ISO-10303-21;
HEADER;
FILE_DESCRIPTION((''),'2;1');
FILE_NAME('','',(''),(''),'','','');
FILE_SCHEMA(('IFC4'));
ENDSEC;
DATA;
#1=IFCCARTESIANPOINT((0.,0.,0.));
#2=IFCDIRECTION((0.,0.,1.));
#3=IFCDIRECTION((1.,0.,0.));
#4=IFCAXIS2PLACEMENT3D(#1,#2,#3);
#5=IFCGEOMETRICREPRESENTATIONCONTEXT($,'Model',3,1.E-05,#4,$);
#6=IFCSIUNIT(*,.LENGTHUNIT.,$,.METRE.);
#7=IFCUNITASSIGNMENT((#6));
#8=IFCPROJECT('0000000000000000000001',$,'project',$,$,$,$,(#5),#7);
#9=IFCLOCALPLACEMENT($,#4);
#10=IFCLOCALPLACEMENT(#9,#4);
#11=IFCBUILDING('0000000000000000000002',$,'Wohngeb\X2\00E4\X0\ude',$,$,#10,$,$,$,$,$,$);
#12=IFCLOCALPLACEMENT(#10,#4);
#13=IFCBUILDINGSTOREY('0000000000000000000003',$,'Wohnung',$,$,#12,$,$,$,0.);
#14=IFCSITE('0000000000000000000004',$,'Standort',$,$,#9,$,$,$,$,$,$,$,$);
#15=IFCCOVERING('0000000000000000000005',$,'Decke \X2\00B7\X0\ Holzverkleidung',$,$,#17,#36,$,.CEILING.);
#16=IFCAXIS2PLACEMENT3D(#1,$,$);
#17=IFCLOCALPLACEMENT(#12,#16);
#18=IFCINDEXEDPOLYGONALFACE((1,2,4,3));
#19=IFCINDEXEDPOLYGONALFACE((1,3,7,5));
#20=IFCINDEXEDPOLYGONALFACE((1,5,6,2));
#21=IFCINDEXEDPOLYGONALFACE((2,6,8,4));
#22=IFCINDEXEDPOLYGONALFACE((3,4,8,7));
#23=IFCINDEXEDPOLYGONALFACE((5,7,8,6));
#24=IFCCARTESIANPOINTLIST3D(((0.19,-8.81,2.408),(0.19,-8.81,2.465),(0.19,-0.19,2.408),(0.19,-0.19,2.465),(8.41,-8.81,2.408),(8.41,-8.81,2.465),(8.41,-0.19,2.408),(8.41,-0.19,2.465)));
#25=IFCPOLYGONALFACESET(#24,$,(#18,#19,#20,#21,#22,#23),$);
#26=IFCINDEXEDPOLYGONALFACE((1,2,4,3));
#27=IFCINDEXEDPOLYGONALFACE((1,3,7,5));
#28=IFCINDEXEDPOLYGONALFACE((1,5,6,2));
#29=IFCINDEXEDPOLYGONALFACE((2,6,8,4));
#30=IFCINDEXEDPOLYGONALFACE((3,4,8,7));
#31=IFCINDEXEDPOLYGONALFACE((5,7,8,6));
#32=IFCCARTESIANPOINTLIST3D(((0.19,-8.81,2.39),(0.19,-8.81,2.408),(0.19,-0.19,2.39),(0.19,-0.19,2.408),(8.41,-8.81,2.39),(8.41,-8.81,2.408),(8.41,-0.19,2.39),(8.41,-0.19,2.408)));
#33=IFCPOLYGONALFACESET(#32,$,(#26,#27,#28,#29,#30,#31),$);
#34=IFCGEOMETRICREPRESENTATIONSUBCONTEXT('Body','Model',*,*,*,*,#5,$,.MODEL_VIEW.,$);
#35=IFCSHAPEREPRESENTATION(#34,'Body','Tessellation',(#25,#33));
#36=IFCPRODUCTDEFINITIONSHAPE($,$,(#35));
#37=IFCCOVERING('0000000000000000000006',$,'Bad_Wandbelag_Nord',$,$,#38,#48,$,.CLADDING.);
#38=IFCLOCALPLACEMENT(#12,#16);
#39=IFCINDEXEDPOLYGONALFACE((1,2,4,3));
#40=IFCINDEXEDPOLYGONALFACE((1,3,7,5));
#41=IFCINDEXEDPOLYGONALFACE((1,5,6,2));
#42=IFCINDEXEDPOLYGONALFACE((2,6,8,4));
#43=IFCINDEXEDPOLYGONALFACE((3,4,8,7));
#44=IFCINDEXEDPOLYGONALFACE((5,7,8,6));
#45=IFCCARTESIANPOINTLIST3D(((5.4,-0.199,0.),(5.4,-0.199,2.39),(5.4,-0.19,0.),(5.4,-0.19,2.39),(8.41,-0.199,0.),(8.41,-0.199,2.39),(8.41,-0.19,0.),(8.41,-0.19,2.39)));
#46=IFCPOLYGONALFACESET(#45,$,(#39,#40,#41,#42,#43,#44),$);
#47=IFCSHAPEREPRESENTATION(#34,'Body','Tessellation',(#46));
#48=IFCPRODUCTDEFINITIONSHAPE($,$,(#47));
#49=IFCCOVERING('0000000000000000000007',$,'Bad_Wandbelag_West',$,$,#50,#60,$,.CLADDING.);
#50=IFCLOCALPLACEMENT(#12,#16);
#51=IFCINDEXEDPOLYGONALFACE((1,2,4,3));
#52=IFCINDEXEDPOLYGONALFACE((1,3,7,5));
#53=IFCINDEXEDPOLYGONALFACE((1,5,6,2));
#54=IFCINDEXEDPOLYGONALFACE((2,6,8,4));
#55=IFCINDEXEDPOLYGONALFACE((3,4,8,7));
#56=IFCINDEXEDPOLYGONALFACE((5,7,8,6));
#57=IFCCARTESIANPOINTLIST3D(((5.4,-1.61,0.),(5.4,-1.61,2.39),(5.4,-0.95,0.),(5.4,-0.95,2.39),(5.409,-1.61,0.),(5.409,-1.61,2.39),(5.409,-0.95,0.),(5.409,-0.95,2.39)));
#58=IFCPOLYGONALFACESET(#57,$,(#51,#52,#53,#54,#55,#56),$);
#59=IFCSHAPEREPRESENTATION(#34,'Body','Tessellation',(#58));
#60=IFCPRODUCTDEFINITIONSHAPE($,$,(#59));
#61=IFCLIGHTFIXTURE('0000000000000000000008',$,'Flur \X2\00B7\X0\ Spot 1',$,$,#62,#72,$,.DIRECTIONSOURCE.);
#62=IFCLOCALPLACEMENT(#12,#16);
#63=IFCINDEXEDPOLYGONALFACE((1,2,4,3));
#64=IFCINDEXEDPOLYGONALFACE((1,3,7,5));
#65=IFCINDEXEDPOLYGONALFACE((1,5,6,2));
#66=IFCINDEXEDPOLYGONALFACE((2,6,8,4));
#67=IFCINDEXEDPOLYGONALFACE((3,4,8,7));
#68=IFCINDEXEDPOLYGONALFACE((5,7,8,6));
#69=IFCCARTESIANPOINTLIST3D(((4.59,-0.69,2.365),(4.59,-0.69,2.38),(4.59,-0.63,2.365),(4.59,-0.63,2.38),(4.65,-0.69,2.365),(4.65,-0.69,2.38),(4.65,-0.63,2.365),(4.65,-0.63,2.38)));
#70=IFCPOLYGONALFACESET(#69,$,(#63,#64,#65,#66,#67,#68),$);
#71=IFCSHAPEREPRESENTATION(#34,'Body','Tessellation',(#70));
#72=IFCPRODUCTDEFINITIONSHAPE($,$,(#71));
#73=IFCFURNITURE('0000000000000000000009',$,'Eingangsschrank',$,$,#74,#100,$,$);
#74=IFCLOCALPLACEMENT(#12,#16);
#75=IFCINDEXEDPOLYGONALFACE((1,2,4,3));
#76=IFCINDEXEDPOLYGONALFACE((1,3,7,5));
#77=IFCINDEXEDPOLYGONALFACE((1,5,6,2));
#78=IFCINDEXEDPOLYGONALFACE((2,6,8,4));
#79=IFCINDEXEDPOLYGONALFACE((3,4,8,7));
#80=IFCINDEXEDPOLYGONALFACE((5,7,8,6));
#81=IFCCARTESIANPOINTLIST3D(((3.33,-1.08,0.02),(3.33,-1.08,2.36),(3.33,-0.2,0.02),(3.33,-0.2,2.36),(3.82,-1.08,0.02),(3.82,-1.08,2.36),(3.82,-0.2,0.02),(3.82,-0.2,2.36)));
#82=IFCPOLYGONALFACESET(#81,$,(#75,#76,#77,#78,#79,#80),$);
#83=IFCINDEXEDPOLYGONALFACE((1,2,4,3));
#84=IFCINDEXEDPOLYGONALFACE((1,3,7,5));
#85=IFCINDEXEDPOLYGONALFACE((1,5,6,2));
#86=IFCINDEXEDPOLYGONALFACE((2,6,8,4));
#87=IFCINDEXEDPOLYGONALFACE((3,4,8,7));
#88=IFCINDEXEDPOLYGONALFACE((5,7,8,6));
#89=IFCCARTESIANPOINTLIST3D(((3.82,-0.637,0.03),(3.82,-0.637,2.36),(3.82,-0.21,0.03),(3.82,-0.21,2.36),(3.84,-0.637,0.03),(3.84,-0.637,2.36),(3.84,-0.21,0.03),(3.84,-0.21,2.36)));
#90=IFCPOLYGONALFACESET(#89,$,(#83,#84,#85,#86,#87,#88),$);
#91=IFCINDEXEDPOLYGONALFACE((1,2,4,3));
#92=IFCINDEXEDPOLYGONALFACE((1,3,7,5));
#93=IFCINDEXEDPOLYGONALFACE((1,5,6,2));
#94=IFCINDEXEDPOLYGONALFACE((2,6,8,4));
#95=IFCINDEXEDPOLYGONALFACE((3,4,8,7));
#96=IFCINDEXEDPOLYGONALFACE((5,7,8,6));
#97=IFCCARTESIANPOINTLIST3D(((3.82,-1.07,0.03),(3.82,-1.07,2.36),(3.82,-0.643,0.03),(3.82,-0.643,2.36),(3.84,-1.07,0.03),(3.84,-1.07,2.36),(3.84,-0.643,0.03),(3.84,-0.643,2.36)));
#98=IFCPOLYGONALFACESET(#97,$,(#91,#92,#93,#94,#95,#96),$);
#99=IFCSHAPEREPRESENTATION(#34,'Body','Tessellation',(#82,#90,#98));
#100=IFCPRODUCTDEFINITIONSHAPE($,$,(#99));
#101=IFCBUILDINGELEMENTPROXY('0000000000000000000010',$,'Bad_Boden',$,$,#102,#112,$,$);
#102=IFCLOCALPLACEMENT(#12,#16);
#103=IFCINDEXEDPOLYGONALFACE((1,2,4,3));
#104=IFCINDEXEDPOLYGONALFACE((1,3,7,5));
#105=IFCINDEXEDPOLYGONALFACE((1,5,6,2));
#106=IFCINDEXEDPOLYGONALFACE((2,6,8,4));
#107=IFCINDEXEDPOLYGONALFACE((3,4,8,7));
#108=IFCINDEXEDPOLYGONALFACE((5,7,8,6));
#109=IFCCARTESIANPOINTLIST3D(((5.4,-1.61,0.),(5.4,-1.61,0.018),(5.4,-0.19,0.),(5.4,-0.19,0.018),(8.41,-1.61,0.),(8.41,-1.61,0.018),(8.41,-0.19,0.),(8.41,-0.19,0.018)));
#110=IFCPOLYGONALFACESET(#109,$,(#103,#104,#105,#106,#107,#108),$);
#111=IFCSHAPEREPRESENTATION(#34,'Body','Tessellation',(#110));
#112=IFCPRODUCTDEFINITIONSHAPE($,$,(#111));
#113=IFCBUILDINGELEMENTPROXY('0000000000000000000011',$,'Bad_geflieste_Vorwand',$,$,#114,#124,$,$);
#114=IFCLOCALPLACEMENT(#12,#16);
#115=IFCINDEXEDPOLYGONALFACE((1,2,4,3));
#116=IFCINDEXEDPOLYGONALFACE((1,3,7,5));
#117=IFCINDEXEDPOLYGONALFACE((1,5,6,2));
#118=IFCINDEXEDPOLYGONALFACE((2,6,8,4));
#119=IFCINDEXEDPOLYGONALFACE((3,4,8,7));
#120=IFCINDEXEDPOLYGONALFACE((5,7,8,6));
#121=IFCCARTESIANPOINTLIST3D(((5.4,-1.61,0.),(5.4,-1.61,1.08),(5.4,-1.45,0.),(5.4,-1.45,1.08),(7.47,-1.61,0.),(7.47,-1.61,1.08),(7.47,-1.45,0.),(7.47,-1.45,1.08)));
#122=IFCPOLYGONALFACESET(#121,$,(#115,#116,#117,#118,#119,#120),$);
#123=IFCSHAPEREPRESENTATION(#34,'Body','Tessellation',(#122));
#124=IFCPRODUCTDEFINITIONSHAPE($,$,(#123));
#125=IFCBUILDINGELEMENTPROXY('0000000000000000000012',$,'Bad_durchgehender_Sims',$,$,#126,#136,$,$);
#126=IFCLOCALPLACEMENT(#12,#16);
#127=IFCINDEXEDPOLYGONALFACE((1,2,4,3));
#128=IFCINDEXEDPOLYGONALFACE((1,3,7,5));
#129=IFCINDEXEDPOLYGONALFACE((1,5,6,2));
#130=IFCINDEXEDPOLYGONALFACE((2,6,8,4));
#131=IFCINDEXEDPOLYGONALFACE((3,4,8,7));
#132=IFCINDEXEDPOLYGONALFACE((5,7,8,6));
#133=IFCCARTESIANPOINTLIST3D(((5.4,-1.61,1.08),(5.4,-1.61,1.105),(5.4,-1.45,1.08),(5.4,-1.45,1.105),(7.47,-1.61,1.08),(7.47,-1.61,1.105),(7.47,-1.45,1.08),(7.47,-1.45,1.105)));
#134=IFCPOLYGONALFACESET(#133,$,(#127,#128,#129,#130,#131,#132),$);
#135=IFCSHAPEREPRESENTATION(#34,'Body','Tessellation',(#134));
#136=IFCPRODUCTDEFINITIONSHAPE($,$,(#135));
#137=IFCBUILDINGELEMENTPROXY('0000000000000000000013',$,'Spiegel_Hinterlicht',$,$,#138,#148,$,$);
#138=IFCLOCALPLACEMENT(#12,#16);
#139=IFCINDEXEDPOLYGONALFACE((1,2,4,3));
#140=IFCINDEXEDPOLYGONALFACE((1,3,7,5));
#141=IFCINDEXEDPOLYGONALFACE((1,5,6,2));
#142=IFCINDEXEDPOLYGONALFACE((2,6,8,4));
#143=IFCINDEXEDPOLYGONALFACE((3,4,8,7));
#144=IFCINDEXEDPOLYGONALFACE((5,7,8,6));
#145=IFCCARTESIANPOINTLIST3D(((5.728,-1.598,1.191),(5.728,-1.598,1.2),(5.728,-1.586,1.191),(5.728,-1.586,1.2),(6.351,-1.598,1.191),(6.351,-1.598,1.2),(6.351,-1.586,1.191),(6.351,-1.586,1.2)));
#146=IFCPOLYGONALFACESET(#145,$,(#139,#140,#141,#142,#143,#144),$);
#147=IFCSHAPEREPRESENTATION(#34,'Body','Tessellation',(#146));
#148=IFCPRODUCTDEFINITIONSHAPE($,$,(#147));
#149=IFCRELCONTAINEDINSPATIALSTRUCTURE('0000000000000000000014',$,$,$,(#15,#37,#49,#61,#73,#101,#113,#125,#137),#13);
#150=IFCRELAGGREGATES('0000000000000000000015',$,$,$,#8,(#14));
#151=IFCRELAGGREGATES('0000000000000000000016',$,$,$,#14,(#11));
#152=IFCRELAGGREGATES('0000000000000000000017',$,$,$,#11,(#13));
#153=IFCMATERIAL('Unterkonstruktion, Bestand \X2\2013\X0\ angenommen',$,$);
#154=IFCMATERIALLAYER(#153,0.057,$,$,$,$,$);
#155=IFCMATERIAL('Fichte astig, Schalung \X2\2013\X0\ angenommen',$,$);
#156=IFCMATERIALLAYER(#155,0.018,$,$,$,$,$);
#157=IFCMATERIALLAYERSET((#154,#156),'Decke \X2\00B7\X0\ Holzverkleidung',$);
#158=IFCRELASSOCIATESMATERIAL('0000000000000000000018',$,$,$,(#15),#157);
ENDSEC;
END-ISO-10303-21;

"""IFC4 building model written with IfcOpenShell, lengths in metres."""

from ifc_helpers import new_model, si_unit, frame, origin, origin_with_axes, place, context, subcontext, project, spatial, polyline, outline, extrude, material, layer, layer_set, element, save


model = new_model("IFC4")

# Units and contexts
model_context = context("Model", 3, precision=1e-05, world=origin_with_axes())
body_context = subcontext(model_context, "Body", "Model", "MODEL_VIEW")
ifc_project = project(units=[si_unit("LENGTHUNIT", "METRE")], contexts=[model_context])

# Site, building, storey
site_placement = place(None, origin_with_axes())
site = spatial("IfcSite", under=ifc_project, at=site_placement, Name="Standort")
building_placement = place(site_placement, origin_with_axes())
building = spatial("IfcBuilding", under=site, at=building_placement, Name="Wohngebäude")
storey_placement = place(building_placement, origin_with_axes())
storey = spatial("IfcBuildingStorey", under=building, at=storey_placement, Name="Wohnung", Elevation=0.0)

# Coverings
ifc_material_1 = material(Name="Unterkonstruktion, Bestand – angenommen")
ifc_layer_1 = layer(ifc_material_1, 0.057)
ifc_material_2 = material(Name="Fichte astig, Schalung – angenommen")
ifc_layer_2 = layer(ifc_material_2, 0.018)
ifc_layer_set_1 = layer_set([ifc_layer_1, ifc_layer_2], Name="Decke · Holzverkleidung")
covering_1_placement = place(storey_placement, origin_with_axes())
element("IfcCovering", 1, at=covering_1_placement, inside=storey, material=ifc_layer_set_1, Name="Decke · Holzverkleidung", PredefinedType="CEILING", context=body_context, shape_type="SweptSolid", body=[
    extrude(outline(polyline([(0.19, -0.19), (8.41, -0.19), (8.41, -8.81), (0.19, -8.81), (0.19, -0.19)])), frame((0.0, 0.0, 2.408)), (0.0, 0.0, 1.0), 0.057),
    extrude(outline(polyline([(0.19, -0.19), (8.41, -0.19), (8.41, -8.81), (0.19, -8.81), (0.19, -0.19)])), frame((0.0, 0.0, 2.39)), (0.0, 0.0, 1.0), 0.018),
])
covering_2_placement = place(storey_placement, frame((5.4, -0.19, 0.0), z_axis=(0.0, 0.0, 1.0), x_axis=(1.0, 0.0, 0.0)))
element("IfcCovering", 2, at=covering_2_placement, inside=storey, Name="Bad_Wandbelag_Nord", PredefinedType="CLADDING", context=body_context, shape_type="SweptSolid", body=[
    extrude(outline(polyline([(0.0, 0.0), (0.0, -0.009), (3.01, -0.009), (3.01, 0.0), (0.0, 0.0)])), origin(), (0.0, 0.0, 1.0), 2.39),
])
covering_3_placement = place(storey_placement, frame((5.4, -0.95, 0.0), z_axis=(0.0, 0.0, 1.0), x_axis=(1.0, 0.0, 0.0)))
element("IfcCovering", 3, at=covering_3_placement, inside=storey, Name="Bad_Wandbelag_West", PredefinedType="CLADDING", context=body_context, shape_type="SweptSolid", body=[
    extrude(outline(polyline([(0.0, 0.0), (0.0, -0.66), (0.009, -0.66), (0.009, 0.0), (0.0, 0.0)])), origin(), (0.0, 0.0, 1.0), 2.39),
])

# Light fixture
light_fixture_placement = place(storey_placement, frame((4.59, -0.63, 2.365), z_axis=(0.0, 0.0, 1.0), x_axis=(1.0, 0.0, 0.0)))
element("IfcLightFixture", 4, at=light_fixture_placement, inside=storey, Name="Flur · Spot 1", PredefinedType="DIRECTIONSOURCE", context=body_context, shape_type="SweptSolid", body=[
    extrude(outline(polyline([(0.0, 0.0), (0.0, -0.06), (0.06, -0.06), (0.06, 0.0), (0.0, 0.0)])), origin(), (0.0, 0.0, 1.0), 0.015),
])

# Furniture
furniture_placement = place(storey_placement, frame((3.33, -0.2, 0.02), z_axis=(0.0, 0.0, 1.0), x_axis=(1.0, 0.0, 0.0)))
element("IfcFurniture", 5, at=furniture_placement, inside=storey, Name="Eingangsschrank", context=body_context, shape_type="SweptSolid", body=[
    extrude(outline(polyline([(0.0, 0.0), (0.0, -0.88), (0.49, -0.88), (0.49, 0.0), (0.0, 0.0)])), origin(), (0.0, 0.0, 1.0), 2.34),
    extrude(outline(polyline([(0.49, -0.01), (0.49, -0.437), (0.51, -0.437), (0.51, -0.01), (0.49, -0.01)])), frame((0.0, 0.0, 0.01)), (0.0, 0.0, 1.0), 2.33),
    extrude(outline(polyline([(0.49, -0.443), (0.49, -0.87), (0.51, -0.87), (0.51, -0.443), (0.49, -0.443)])), frame((0.0, 0.0, 0.01)), (0.0, 0.0, 1.0), 2.33),
])

# Building element proxies
proxy_1_placement = place(storey_placement, frame((5.4, -0.19, 0.0), z_axis=(0.0, 0.0, 1.0), x_axis=(1.0, 0.0, 0.0)))
element("IfcBuildingElementProxy", 6, at=proxy_1_placement, inside=storey, Name="Bad_Boden", context=body_context, shape_type="SweptSolid", body=[
    extrude(outline(polyline([(0.0, 0.0), (0.0, -1.42), (3.01, -1.42), (3.01, 0.0), (0.0, 0.0)])), origin(), (0.0, 0.0, 1.0), 0.018),
])
proxy_2_placement = place(storey_placement, frame((5.4, -1.45, 0.0), z_axis=(0.0, 0.0, 1.0), x_axis=(1.0, 0.0, 0.0)))
element("IfcBuildingElementProxy", 7, at=proxy_2_placement, inside=storey, Name="Bad_geflieste_Vorwand", context=body_context, shape_type="SweptSolid", body=[
    extrude(outline(polyline([(0.0, 0.0), (0.0, -0.16), (2.07, -0.16), (2.07, 0.0), (0.0, 0.0)])), origin(), (0.0, 0.0, 1.0), 1.08),
])
proxy_3_placement = place(storey_placement, frame((5.4, -1.45, 1.08), z_axis=(0.0, 0.0, 1.0), x_axis=(1.0, 0.0, 0.0)))
element("IfcBuildingElementProxy", 8, at=proxy_3_placement, inside=storey, Name="Bad_durchgehender_Sims", context=body_context, shape_type="SweptSolid", body=[
    extrude(outline(polyline([(0.0, 0.0), (0.0, -0.16), (2.07, -0.16), (2.07, 0.0), (0.0, 0.0)])), origin(), (0.0, 0.0, 1.0), 0.025),
])
proxy_4_placement = place(storey_placement, frame((5.728, -1.586, 1.191), z_axis=(0.0, 0.0, 1.0), x_axis=(1.0, 0.0, 0.0)))
element("IfcBuildingElementProxy", 9, at=proxy_4_placement, inside=storey, Name="Spiegel_Hinterlicht", context=body_context, shape_type="SweptSolid", body=[
    extrude(outline(polyline([(0.0, 0.0), (0.0, -0.012), (0.623, -0.012), (0.623, 0.0), (0.0, 0.0)])), origin(), (0.0, 0.0, 1.0), 0.009),
])

save(model, "model.ifc")
